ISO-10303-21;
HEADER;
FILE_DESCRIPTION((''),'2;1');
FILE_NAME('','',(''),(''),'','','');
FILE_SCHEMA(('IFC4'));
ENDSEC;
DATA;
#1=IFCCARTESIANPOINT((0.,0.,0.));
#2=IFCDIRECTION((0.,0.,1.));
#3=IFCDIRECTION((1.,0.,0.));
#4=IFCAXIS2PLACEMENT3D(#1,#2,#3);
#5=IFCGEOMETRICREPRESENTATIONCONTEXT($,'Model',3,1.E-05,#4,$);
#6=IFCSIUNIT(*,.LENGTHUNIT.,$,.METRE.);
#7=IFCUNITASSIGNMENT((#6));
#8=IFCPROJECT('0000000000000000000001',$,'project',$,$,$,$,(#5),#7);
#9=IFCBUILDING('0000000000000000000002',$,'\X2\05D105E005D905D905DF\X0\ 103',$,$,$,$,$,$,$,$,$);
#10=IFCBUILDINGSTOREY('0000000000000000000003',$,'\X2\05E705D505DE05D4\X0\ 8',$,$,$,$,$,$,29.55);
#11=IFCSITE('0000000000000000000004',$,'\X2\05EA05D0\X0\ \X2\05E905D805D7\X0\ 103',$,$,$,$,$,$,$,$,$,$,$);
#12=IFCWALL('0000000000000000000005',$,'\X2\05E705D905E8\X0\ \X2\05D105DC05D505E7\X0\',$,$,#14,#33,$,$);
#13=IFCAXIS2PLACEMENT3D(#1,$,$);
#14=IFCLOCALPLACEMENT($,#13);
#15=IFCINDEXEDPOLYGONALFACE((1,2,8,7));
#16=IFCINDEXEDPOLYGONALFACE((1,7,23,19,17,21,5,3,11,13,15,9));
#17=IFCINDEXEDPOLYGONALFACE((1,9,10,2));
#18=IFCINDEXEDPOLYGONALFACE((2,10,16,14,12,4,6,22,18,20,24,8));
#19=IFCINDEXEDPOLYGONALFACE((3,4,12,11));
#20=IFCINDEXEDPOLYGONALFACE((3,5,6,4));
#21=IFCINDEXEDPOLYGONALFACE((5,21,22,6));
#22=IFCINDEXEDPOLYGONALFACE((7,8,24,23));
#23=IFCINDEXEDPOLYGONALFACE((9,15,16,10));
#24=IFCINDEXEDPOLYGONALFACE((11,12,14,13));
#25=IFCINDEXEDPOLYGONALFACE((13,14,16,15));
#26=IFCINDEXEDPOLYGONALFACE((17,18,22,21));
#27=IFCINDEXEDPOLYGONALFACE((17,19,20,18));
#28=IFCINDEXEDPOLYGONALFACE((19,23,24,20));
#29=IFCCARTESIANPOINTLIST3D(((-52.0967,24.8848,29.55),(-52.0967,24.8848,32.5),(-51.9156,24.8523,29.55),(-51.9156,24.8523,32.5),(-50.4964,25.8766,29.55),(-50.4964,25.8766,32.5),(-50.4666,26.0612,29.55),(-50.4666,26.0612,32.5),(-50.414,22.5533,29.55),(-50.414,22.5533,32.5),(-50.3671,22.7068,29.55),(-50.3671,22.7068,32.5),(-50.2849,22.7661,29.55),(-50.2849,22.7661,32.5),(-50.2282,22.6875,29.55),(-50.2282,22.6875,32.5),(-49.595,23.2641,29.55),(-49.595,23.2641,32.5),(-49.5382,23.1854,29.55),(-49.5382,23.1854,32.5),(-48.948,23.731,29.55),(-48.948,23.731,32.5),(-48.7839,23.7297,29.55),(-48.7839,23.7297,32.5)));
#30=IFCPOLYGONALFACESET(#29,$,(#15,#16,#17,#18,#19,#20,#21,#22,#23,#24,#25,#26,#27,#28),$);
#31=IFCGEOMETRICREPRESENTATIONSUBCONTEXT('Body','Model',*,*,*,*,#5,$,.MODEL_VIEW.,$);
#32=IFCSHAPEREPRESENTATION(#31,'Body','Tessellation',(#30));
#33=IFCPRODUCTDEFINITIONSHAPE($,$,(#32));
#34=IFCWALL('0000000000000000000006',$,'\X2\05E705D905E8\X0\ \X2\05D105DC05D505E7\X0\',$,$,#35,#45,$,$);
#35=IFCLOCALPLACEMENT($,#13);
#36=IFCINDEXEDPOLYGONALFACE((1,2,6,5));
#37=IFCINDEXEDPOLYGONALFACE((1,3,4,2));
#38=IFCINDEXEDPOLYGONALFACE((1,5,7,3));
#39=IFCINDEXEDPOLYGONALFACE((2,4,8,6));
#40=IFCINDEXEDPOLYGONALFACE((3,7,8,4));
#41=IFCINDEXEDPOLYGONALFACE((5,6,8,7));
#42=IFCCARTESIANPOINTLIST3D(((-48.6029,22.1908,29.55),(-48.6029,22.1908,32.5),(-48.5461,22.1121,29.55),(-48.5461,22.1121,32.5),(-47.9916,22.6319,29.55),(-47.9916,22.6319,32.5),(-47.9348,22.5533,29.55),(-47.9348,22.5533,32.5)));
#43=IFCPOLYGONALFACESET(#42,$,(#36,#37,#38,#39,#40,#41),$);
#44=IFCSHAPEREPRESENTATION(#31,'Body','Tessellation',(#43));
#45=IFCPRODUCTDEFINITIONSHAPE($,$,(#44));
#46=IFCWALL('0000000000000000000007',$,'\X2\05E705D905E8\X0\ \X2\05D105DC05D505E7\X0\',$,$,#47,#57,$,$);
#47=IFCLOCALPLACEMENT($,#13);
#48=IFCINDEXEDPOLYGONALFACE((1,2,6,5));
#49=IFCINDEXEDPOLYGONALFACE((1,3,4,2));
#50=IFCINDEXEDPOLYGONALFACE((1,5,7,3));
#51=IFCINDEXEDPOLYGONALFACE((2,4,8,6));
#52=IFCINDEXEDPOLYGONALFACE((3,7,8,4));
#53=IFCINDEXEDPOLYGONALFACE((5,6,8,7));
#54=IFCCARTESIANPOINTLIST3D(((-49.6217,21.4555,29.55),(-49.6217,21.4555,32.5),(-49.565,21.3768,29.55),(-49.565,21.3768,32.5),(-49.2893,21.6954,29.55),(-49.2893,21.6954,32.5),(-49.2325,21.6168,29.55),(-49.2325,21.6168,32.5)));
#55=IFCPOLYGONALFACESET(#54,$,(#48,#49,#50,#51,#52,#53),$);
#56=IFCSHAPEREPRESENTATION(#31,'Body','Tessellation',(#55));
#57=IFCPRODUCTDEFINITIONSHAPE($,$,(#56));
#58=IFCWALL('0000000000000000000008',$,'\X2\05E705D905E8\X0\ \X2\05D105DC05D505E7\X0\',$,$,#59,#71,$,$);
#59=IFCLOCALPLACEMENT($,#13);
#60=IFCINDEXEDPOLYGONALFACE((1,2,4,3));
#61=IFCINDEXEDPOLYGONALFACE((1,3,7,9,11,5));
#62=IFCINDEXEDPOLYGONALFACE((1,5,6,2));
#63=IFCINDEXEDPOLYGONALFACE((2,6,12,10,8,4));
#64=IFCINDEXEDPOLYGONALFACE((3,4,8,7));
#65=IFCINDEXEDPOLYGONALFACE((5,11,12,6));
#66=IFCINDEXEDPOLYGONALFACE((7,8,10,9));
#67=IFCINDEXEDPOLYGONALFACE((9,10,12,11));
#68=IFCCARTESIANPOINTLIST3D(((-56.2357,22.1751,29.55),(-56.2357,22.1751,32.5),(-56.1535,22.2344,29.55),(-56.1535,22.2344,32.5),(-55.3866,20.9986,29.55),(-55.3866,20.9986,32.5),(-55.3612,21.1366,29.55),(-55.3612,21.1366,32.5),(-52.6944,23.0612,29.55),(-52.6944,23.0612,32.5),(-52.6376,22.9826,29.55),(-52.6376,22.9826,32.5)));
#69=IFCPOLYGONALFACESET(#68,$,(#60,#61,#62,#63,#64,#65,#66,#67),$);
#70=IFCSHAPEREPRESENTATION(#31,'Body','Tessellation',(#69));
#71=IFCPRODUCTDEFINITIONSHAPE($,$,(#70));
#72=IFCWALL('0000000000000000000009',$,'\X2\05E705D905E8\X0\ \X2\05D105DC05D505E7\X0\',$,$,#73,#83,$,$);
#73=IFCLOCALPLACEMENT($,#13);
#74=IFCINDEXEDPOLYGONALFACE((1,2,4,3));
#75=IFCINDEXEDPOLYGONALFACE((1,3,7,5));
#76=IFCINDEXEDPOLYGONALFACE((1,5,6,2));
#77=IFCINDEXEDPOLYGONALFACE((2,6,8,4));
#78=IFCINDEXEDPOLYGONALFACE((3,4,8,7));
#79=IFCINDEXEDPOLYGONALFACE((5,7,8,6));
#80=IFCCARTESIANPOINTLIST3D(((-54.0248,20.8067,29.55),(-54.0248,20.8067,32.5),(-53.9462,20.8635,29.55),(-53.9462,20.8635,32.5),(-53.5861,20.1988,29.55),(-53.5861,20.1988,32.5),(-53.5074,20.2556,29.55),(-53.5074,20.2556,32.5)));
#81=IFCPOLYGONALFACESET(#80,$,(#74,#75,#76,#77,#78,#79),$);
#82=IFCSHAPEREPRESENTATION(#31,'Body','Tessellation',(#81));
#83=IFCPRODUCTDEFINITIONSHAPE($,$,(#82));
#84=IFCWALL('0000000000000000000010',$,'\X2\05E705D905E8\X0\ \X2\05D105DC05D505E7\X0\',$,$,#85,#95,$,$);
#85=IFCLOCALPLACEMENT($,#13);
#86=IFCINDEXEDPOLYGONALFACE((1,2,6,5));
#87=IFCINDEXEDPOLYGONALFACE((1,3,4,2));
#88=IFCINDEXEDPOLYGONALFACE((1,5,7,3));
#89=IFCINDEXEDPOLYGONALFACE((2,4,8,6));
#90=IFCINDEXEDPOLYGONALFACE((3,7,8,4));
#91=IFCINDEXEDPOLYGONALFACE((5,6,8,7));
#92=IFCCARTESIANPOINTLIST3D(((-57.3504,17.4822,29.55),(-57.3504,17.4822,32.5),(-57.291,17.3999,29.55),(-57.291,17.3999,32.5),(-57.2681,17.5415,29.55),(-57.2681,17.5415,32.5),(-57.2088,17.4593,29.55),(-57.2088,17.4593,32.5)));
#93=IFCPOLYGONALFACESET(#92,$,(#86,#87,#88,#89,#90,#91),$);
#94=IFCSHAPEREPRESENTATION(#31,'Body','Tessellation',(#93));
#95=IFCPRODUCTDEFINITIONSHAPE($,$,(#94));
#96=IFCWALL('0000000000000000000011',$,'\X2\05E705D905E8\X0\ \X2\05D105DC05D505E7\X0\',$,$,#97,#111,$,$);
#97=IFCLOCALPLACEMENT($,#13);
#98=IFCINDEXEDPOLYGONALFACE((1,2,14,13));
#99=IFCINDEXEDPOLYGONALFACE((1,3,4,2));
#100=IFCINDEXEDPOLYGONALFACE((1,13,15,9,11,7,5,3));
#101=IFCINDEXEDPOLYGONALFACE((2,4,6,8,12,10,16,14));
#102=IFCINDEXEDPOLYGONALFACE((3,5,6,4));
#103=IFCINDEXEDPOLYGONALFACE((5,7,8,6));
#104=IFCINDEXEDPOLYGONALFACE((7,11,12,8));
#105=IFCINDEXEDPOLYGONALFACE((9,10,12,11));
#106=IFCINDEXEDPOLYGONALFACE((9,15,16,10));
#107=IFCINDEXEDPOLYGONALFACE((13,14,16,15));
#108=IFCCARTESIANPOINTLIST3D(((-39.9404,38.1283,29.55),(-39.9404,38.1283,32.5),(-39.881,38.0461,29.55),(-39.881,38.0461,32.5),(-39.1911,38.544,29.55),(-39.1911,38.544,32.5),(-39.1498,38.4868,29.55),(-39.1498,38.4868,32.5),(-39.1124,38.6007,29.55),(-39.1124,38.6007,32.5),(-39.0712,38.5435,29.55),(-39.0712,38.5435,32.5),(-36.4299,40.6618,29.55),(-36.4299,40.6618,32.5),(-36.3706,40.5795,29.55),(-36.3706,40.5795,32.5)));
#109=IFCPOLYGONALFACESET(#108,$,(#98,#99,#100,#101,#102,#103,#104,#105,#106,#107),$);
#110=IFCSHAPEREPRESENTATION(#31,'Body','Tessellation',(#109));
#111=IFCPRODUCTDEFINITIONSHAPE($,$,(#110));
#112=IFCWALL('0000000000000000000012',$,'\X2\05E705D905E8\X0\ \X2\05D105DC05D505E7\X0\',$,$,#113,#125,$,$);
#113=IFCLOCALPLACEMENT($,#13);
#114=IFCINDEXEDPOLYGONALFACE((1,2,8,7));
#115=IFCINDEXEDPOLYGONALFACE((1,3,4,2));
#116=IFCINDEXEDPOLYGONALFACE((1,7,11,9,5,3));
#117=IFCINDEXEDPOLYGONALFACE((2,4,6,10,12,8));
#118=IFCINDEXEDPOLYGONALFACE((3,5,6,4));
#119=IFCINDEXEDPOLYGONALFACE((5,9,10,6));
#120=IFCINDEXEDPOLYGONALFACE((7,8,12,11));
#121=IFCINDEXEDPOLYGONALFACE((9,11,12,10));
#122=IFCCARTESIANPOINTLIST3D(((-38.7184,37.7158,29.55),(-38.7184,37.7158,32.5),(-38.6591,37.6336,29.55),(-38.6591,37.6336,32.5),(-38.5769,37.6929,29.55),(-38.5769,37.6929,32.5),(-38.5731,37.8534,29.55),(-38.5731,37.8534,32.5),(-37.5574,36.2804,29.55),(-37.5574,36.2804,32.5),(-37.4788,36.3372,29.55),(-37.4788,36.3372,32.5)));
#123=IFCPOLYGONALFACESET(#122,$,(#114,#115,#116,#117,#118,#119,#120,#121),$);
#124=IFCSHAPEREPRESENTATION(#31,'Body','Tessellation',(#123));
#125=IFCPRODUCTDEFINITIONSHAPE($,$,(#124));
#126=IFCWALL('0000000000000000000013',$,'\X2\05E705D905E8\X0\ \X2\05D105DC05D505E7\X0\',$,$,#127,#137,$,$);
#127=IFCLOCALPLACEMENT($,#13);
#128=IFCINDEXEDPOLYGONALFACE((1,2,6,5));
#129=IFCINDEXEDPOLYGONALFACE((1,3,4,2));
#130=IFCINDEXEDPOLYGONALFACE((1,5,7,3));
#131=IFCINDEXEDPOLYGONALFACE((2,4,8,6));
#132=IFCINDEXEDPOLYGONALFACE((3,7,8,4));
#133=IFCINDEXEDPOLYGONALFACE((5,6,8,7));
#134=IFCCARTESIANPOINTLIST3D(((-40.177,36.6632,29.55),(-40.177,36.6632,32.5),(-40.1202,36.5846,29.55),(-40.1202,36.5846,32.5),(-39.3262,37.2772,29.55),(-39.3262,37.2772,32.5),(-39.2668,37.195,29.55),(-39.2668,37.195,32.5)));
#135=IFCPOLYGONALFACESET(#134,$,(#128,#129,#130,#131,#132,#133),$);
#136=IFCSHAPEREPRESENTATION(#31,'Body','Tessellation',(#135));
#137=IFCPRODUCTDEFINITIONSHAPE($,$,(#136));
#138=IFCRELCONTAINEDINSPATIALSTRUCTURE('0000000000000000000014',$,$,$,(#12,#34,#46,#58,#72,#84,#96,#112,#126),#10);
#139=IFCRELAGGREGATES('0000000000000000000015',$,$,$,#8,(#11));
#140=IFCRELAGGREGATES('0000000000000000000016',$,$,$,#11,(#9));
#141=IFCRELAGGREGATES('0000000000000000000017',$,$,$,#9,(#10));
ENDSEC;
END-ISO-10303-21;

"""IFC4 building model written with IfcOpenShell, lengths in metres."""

from ifc_helpers import new_model, si_unit, frame, origin_with_axes, context, subcontext, project, spatial, polyline, outline, extrude, element, save


model = new_model("IFC4")

# Units and contexts
model_context = context("Model", 3, precision=1e-05, world=origin_with_axes())
body_context = subcontext(model_context, "Body", "Model", "MODEL_VIEW")
ifc_project = project(units=[si_unit("LENGTHUNIT", "METRE")], contexts=[model_context])

# Site, building, storey
site = spatial("IfcSite", under=ifc_project, Name="תא שטח 103")
building = spatial("IfcBuilding", under=site, Name="בניין 103")
storey = spatial("IfcBuildingStorey", under=building, Name="קומה 8", Elevation=29.55)

# Walls
element("IfcWall", 1, inside=storey, Name="קיר בלוק", context=body_context, shape_type="SweptSolid", body=[
    extrude(outline(polyline([(-48.948, 23.731), (-50.4964, 25.8766), (-51.9156, 24.8523), (-50.3671, 22.7068), (-50.2849, 22.7661), (-50.2282, 22.6875), (-50.414, 22.5533), (-52.0967, 24.8848), (-50.4666, 26.0612), (-48.7839, 23.7297), (-49.5382, 23.1854), (-49.595, 23.2641), (-48.948, 23.731)])), frame((0.0, 0.0, 29.55)), (0.0, 0.0, 1.0), 2.95),
])
element("IfcWall", 2, inside=storey, Name="קיר בלוק", context=body_context, shape_type="SweptSolid", body=[
    extrude(outline(polyline([(-47.9348, 22.5533), (-48.5461, 22.1121), (-48.6029, 22.1908), (-47.9916, 22.6319), (-47.9348, 22.5533)])), frame((0.0, 0.0, 29.55)), (0.0, 0.0, 1.0), 2.95),
])
element("IfcWall", 3, inside=storey, Name="קיר בלוק", context=body_context, shape_type="SweptSolid", body=[
    extrude(outline(polyline([(-49.565, 21.3768), (-49.6217, 21.4555), (-49.2893, 21.6954), (-49.2325, 21.6168), (-49.565, 21.3768)])), frame((0.0, 0.0, 29.55)), (0.0, 0.0, 1.0), 2.95),
])
element("IfcWall", 4, inside=storey, Name="קיר בלוק", context=body_context, shape_type="SweptSolid", body=[
    extrude(outline(polyline([(-56.1535, 22.2344), (-55.3612, 21.1366), (-52.6944, 23.0612), (-52.6376, 22.9826), (-55.3866, 20.9986), (-56.2357, 22.1751), (-56.1535, 22.2344)])), frame((0.0, 0.0, 29.55)), (0.0, 0.0, 1.0), 2.95),
])
element("IfcWall", 5, inside=storey, Name="קיר בלוק", context=body_context, shape_type="SweptSolid", body=[
    extrude(outline(polyline([(-53.5861, 20.1988), (-54.0248, 20.8067), (-53.9462, 20.8635), (-53.5074, 20.2556), (-53.5861, 20.1988)])), frame((0.0, 0.0, 29.55)), (0.0, 0.0, 1.0), 2.95),
])
element("IfcWall", 6, inside=storey, Name="קיר בלוק", context=body_context, shape_type="SweptSolid", body=[
    extrude(outline(polyline([(-57.291, 17.3999), (-57.3504, 17.4822), (-57.2681, 17.5415), (-57.2088, 17.4593), (-57.291, 17.3999)])), frame((0.0, 0.0, 29.55)), (0.0, 0.0, 1.0), 2.95),
])
element("IfcWall", 7, inside=storey, Name="קיר בלוק", context=body_context, shape_type="SweptSolid", body=[
    extrude(outline(polyline([(-39.881, 38.0461), (-39.9404, 38.1283), (-36.4299, 40.6618), (-36.3706, 40.5795), (-39.1124, 38.6007), (-39.0712, 38.5435), (-39.1498, 38.4868), (-39.1911, 38.544), (-39.881, 38.0461)])), frame((0.0, 0.0, 29.55)), (0.0, 0.0, 1.0), 2.95),
])
element("IfcWall", 8, inside=storey, Name="קיר בלוק", context=body_context, shape_type="SweptSolid", body=[
    extrude(outline(polyline([(-38.6591, 37.6336), (-38.7184, 37.7158), (-38.5731, 37.8534), (-37.4788, 36.3372), (-37.5574, 36.2804), (-38.5769, 37.6929), (-38.6591, 37.6336)])), frame((0.0, 0.0, 29.55)), (0.0, 0.0, 1.0), 2.95),
])
element("IfcWall", 9, inside=storey, Name="קיר בלוק", context=body_context, shape_type="SweptSolid", body=[
    extrude(outline(polyline([(-40.177, 36.6632), (-39.3262, 37.2772), (-39.2668, 37.195), (-40.1202, 36.5846), (-40.177, 36.6632)])), frame((0.0, 0.0, 29.55)), (0.0, 0.0, 1.0), 2.95),
])

save(model, "model.ifc")
